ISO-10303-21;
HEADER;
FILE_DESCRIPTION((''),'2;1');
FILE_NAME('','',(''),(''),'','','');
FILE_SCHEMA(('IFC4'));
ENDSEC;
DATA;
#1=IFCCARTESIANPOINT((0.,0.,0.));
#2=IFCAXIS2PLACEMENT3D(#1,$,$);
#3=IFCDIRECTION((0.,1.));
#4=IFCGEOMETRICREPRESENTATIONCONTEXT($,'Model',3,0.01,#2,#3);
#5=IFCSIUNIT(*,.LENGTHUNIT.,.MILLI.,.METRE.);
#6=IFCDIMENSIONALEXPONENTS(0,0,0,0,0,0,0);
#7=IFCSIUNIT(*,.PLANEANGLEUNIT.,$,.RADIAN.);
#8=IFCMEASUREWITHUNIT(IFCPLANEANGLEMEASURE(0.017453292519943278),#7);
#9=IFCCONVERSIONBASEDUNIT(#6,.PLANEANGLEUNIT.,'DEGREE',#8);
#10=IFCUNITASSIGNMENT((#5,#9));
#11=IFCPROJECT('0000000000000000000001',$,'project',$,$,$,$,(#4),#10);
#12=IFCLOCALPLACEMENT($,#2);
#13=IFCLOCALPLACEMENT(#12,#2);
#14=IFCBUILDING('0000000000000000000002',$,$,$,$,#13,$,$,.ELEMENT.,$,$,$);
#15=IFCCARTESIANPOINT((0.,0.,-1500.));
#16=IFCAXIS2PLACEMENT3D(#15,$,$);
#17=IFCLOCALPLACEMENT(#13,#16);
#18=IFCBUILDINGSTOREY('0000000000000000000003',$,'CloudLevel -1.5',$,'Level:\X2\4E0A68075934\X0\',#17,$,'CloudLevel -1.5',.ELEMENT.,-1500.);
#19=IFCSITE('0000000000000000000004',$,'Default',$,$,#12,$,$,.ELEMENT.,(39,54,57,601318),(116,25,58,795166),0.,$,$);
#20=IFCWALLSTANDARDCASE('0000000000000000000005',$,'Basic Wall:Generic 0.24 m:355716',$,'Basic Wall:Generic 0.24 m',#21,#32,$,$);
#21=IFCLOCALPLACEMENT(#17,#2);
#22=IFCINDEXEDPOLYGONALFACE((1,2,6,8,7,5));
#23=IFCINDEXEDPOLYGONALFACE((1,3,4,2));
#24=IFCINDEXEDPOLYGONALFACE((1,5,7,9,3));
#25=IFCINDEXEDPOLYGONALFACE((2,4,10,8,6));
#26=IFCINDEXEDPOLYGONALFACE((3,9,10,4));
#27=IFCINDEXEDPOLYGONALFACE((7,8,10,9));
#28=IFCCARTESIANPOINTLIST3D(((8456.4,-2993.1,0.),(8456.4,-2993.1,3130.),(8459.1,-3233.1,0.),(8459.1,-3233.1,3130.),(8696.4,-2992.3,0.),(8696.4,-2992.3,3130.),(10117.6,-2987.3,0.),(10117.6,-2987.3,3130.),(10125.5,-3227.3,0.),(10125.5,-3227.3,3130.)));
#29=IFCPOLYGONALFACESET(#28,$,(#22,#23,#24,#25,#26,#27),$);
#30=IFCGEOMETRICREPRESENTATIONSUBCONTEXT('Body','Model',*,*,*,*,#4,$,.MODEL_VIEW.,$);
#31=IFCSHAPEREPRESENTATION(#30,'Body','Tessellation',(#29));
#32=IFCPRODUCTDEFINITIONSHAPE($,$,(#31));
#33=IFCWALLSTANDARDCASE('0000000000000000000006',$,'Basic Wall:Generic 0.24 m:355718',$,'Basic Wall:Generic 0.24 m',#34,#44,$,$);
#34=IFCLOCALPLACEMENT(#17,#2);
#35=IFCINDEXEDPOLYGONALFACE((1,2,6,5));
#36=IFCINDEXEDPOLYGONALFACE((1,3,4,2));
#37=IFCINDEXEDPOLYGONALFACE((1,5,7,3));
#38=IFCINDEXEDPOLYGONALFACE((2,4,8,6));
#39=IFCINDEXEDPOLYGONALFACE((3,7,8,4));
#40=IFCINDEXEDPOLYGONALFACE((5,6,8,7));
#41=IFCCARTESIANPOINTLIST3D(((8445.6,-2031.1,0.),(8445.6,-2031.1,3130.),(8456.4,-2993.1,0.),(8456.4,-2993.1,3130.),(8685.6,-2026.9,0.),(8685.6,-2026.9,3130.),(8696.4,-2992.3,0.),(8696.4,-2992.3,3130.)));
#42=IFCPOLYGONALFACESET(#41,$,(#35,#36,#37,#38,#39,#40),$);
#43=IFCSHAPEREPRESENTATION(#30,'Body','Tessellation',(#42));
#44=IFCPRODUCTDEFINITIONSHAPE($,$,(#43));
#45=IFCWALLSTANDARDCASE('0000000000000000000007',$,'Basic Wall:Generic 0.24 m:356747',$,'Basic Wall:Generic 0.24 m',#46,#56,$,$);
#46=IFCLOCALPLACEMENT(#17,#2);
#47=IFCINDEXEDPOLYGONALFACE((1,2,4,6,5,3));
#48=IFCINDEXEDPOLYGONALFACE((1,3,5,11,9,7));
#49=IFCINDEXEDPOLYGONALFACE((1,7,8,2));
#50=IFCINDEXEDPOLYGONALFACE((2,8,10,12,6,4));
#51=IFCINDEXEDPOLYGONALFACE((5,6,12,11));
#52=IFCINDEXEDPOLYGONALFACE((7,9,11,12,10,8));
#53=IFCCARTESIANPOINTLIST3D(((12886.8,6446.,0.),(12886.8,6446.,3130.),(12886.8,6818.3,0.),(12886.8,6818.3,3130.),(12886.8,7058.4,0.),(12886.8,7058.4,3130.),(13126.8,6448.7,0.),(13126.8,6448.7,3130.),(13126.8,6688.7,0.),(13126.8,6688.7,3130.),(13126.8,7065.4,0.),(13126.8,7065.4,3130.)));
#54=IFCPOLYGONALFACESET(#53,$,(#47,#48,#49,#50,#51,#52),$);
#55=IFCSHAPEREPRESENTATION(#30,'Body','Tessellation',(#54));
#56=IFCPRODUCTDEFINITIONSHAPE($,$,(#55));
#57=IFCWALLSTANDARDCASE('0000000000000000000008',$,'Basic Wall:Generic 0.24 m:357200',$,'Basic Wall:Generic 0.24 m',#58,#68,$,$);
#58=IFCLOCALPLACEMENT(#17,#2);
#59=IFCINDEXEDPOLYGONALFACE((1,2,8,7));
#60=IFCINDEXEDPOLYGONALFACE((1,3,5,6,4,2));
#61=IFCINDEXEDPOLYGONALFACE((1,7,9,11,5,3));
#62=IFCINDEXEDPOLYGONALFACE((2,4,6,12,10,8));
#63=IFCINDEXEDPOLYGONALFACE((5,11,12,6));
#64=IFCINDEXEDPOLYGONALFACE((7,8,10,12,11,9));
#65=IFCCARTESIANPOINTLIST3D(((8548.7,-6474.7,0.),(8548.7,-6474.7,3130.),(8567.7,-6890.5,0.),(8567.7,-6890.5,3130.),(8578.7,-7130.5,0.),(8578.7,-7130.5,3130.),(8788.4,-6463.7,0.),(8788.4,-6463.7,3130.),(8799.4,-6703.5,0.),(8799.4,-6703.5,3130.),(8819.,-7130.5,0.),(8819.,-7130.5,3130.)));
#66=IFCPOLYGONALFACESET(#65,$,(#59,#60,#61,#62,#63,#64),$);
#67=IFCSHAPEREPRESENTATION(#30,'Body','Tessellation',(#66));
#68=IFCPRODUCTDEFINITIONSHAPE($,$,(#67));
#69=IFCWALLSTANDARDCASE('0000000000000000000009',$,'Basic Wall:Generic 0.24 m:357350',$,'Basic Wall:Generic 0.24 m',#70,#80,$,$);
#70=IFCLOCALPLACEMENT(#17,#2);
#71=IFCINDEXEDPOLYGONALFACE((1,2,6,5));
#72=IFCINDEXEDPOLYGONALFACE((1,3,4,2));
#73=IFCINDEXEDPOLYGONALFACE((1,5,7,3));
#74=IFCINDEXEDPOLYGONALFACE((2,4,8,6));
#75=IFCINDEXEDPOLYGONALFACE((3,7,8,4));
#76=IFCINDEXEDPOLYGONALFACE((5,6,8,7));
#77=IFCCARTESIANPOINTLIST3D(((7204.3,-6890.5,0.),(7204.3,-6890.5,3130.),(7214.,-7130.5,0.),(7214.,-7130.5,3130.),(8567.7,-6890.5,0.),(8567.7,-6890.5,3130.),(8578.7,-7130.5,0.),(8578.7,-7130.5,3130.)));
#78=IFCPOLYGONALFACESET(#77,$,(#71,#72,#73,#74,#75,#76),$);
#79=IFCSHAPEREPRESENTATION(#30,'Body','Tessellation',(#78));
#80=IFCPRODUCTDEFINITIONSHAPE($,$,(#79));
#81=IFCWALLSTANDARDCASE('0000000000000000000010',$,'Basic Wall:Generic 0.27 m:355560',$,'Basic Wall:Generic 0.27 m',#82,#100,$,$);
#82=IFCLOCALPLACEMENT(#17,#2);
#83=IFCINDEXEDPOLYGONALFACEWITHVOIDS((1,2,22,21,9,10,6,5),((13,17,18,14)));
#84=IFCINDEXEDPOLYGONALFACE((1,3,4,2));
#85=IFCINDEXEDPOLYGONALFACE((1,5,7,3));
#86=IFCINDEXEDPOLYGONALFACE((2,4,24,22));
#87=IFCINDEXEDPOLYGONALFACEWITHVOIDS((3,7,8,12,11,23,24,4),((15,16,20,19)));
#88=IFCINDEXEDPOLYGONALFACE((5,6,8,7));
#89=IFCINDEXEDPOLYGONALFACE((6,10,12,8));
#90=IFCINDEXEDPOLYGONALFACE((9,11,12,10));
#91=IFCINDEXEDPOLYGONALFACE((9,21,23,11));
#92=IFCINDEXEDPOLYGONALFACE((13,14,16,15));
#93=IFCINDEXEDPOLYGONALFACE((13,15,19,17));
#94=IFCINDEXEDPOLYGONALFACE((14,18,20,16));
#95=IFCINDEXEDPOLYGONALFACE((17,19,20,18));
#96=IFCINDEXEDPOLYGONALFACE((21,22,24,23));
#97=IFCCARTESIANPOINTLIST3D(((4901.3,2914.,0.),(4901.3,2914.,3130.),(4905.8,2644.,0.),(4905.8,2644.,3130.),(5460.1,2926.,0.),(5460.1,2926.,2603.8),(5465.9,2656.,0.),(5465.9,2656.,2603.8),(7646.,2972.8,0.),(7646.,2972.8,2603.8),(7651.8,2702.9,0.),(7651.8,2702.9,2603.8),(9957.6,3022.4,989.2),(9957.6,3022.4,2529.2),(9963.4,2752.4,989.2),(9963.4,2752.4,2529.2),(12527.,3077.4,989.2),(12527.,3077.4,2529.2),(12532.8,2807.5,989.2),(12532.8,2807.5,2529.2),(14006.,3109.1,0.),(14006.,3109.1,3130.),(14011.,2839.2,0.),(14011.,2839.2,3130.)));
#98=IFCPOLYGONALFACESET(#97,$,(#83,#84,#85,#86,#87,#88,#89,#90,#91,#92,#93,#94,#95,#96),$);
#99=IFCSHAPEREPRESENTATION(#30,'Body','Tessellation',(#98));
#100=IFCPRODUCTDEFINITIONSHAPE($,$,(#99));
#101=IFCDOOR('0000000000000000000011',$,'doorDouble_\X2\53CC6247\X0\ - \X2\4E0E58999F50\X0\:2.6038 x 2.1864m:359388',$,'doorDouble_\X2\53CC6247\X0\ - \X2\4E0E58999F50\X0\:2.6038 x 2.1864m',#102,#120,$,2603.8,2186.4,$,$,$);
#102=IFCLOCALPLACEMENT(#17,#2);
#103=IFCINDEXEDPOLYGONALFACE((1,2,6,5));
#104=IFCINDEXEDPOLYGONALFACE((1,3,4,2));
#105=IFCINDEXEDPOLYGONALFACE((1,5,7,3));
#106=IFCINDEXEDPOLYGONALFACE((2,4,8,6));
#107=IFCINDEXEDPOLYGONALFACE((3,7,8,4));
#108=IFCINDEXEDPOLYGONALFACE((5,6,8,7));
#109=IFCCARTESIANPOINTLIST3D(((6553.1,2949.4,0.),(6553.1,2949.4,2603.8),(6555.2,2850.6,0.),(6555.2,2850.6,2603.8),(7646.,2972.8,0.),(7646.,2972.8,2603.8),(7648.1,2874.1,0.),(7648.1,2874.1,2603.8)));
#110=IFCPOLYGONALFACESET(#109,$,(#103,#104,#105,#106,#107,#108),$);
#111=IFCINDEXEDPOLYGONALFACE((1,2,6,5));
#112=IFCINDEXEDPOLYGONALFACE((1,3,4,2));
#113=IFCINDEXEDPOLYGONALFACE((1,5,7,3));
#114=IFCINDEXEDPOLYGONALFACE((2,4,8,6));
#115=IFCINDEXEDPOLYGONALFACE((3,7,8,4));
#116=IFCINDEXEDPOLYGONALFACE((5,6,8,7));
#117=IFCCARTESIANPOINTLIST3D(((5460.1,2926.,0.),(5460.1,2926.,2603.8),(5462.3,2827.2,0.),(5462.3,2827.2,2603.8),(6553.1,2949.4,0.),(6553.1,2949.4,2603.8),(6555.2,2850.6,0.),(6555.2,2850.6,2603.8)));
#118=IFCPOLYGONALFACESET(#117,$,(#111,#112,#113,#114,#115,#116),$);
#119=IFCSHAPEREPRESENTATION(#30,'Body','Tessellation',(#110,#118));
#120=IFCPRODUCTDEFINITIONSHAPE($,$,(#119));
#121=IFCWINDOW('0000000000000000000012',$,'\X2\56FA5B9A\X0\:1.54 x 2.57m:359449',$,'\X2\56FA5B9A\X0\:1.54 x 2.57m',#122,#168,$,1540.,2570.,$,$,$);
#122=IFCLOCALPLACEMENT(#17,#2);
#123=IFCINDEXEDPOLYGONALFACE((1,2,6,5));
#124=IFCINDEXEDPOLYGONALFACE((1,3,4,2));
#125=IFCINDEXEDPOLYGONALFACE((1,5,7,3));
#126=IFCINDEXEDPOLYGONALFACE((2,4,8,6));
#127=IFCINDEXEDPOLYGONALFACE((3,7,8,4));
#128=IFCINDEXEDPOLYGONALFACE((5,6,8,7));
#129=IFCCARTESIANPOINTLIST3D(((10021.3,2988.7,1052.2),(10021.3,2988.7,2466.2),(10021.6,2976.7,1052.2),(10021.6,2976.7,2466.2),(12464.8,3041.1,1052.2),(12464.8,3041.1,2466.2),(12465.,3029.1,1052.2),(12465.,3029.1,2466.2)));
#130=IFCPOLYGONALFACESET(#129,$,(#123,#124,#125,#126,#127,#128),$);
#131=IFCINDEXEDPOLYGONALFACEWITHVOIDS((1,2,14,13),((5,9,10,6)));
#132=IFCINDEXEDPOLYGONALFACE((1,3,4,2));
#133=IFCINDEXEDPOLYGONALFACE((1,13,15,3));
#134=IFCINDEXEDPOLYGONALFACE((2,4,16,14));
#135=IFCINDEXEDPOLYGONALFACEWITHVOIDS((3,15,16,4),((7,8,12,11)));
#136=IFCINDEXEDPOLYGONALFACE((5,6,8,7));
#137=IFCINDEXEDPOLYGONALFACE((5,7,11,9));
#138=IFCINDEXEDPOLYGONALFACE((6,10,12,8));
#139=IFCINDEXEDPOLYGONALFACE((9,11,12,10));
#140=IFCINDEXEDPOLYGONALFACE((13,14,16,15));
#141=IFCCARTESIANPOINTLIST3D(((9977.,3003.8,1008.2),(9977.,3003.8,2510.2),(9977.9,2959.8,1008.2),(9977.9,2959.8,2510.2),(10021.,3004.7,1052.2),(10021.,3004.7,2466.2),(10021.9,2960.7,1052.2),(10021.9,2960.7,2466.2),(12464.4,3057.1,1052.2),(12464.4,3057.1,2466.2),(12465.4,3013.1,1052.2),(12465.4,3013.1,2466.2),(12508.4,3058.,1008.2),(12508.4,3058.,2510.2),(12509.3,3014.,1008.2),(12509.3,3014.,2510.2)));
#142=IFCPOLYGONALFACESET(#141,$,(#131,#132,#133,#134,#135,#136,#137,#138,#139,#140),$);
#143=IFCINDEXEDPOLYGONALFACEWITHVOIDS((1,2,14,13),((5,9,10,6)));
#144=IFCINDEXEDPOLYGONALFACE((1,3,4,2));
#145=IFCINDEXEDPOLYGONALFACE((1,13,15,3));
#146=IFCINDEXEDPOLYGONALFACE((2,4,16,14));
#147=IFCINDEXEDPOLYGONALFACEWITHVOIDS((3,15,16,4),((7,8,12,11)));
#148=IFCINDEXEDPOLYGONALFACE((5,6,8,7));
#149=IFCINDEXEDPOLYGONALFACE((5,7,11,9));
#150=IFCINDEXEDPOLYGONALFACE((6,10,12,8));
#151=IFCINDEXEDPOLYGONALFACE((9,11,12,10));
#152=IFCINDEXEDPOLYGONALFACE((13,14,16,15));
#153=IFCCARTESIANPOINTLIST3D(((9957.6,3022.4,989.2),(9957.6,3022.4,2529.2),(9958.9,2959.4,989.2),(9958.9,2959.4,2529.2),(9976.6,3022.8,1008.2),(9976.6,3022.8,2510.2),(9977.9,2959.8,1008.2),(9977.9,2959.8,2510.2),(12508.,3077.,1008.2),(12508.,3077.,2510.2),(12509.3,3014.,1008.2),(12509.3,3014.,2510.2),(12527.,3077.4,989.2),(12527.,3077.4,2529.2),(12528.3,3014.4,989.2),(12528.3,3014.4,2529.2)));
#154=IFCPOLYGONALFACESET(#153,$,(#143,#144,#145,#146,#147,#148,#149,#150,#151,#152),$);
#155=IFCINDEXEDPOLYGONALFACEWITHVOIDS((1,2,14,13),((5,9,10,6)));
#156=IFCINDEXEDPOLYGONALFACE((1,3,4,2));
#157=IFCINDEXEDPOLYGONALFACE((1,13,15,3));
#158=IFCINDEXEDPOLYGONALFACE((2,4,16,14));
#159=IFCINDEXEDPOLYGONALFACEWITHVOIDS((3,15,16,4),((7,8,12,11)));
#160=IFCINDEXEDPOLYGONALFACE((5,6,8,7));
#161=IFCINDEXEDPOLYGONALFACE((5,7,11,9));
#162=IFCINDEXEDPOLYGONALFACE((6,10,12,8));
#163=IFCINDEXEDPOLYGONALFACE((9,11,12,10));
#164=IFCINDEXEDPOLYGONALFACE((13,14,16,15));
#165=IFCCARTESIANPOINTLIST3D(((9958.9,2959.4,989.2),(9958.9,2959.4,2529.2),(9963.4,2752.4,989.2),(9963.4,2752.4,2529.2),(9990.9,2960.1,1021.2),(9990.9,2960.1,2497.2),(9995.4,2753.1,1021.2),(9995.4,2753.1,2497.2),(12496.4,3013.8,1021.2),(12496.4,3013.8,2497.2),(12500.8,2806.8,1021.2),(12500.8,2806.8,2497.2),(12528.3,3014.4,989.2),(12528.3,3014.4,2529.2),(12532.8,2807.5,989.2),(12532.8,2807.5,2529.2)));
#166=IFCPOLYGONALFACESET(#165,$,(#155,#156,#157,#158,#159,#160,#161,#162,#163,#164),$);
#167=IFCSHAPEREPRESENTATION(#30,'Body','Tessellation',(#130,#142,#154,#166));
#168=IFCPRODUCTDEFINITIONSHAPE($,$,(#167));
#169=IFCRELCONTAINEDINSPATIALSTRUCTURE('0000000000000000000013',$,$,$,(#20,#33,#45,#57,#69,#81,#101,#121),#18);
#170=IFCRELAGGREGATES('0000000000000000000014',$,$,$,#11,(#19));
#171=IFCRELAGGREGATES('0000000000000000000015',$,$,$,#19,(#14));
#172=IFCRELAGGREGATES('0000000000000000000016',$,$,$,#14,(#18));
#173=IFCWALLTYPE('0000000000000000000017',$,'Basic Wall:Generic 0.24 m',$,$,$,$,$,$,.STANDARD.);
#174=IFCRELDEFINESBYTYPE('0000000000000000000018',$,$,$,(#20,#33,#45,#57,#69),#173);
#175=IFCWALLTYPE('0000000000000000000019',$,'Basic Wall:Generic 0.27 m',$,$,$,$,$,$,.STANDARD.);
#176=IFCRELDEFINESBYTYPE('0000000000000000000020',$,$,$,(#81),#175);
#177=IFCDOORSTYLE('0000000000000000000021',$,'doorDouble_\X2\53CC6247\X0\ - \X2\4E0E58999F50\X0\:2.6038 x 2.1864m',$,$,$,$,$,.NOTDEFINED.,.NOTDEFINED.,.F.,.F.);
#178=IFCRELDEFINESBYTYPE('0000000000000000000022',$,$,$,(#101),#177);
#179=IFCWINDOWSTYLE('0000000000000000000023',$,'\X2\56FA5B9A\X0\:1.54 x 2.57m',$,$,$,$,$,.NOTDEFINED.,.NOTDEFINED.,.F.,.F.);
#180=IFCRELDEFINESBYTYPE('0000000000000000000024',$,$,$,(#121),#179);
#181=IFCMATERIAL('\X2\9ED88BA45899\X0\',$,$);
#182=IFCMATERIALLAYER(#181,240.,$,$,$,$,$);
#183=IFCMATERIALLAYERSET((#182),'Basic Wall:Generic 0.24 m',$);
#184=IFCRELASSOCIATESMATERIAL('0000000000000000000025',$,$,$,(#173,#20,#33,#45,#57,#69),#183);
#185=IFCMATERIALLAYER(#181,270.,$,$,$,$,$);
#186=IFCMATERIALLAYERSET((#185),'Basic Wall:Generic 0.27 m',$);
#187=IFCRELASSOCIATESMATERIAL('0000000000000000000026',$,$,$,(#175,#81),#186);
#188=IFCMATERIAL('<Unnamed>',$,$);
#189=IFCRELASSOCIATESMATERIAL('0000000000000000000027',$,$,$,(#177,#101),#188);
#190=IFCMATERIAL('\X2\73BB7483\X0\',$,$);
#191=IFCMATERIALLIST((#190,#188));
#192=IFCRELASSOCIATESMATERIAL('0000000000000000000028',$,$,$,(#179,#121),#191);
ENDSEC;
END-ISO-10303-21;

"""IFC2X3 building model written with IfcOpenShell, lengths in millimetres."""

from ifc_helpers import new_model, entity, si_unit, converted_unit, direction, frame, frame_2d, origin, place, context, subcontext, project, spatial, polyline, rectangle, outline, extrude, source, transform, mapped, material, material_list, layer, layer_set, layer_usage, type_object, type_shapes, element, fill, save


model = new_model("IFC2X3")

# Units and contexts
model_context = context("Model", 3, precision=0.01, world=origin(), true_north=direction((0.0, 1.0)))
body_context = subcontext(model_context, "Body", "Model", "MODEL_VIEW")
ifc_project = project(units=[si_unit("LENGTHUNIT", "METRE", prefix="MILLI"), converted_unit("PLANEANGLEUNIT", "DEGREE", entity("IfcPlaneAngleMeasure", 0.017453292519943278), si_unit("PLANEANGLEUNIT", "RADIAN"), dimensions=[0, 0, 0, 0, 0, 0, 0])], contexts=[model_context])

# Site, building, storey
site_placement = place(None, origin())
site = spatial("IfcSite", under=ifc_project, at=site_placement, Name="Default", CompositionType="ELEMENT", RefLatitude=(39, 54, 57, 601318), RefLongitude=(116, 25, 58, 795166), RefElevation=0.0)
building_placement = place(site_placement, origin())
building = spatial("IfcBuilding", under=site, at=building_placement, CompositionType="ELEMENT")
storey_placement = place(building_placement, frame((0.0, 0.0, -1500.0)))
storey = spatial("IfcBuildingStorey", under=building, at=storey_placement, Name="CloudLevel -1.5", ObjectType="Level:上标头", LongName="CloudLevel -1.5", CompositionType="ELEMENT", Elevation=-1500.0)

# Shared definitions
ifc_material_1 = material(Name="默认墙")
ifc_layer_1 = layer(ifc_material_1, 240.0)
ifc_layer_set_1 = layer_set([ifc_layer_1], Name="Basic Wall:Generic 0.24 m")
ifc_layer_usage_1 = layer_usage(ifc_layer_set_1, "AXIS2", "NEGATIVE", 120.0)
wall_type_1 = type_object("IfcWallType", Name="Basic Wall:Generic 0.24 m", PredefinedType="STANDARD", material=ifc_layer_set_1)

# Shared definitions
ifc_material_2 = material(Name="玻璃")
ifc_material_3 = material(Name="<Unnamed>")
ifc_material_list_1 = material_list([ifc_material_2, ifc_material_3])

# Walls
wall_1_placement = place(storey_placement, frame((10125.0, -3107.3, 0.0), z_axis=(0.0, 0.0, 1.0), x_axis=(-0.999994, -0.003487, 0.0)))
element("IfcWallStandardCase", 1, at=wall_1_placement, inside=storey, type_object=wall_type_1, material=ifc_layer_usage_1, Name="Basic Wall:Generic 0.24 m:355716", ObjectType="Basic Wall:Generic 0.24 m", context=body_context, shape_type="SweptSolid", body=[
    extrude(outline(polyline([(1668.2, -120.0), (1666.4, 120.0), (0.0, 120.0), (7.0, -120.0), (1428.2, -120.0), (1668.2, -120.0)])), origin(), (0.0, 0.0, 1.0), 3130.0),
])
wall_2_placement = place(storey_placement, frame((8576.4, -2993.6, 0.0), z_axis=(0.0, 0.0, 1.0), x_axis=(-0.011185, 0.999937, 0.0)))
element("IfcWallStandardCase", 2, at=wall_2_placement, inside=storey, type_object=wall_type_1, material=ifc_layer_usage_1, Name="Basic Wall:Generic 0.24 m:355718", ObjectType="Basic Wall:Generic 0.24 m", context=body_context, shape_type="SweptSolid", body=[
    extrude(outline(polyline([(965.4, -120.0), (963.9, 120.0), (1.8, 120.0), (0.0, -120.0), (965.4, -120.0)])), origin(), (0.0, 0.0, 1.0), 3130.0),
])
wall_3_placement = place(storey_placement, frame((13006.8, 6446.0, 0.0), z_axis=(0.0, 0.0, 1.0), x_axis=(0.0, 1.0, 0.0)))
element("IfcWallStandardCase", 3, at=wall_3_placement, inside=storey, type_object=wall_type_1, material=ifc_layer_usage_1, Name="Basic Wall:Generic 0.24 m:356747", ObjectType="Basic Wall:Generic 0.24 m", context=body_context, shape_type="SweptSolid", body=[
    extrude(outline(polyline([(619.3, -120.0), (612.3, 120.0), (372.2, 120.0), (0.0, 120.0), (2.7, -120.0), (242.7, -120.0), (619.3, -120.0)])), origin(), (0.0, 0.0, 1.0), 3130.0),
])
wall_4_placement = place(storey_placement, frame((8668.6, -6469.2, 0.0), z_axis=(0.0, 0.0, 1.0), x_axis=(0.045709, -0.998955, 0.0)))
element("IfcWallStandardCase", 4, at=wall_4_placement, inside=storey, type_object=wall_type_1, material=ifc_layer_usage_1, Name="Basic Wall:Generic 0.24 m:357200", ObjectType="Basic Wall:Generic 0.24 m", context=body_context, shape_type="SweptSolid", body=[
    extrude(outline(polyline([(656.5, -120.0), (667.4, 120.0), (240.0, 120.0), (0.0, 120.0), (0.0, -120.0), (416.2, -120.0), (656.5, -120.0)])), origin(), (0.0, 0.0, 1.0), 3130.0),
])
wall_5_placement = place(storey_placement, frame((8578.7, -7010.5, 0.0), z_axis=(0.0, 0.0, 1.0), x_axis=(-1.0, 0.0, 0.0)))
element("IfcWallStandardCase", 5, at=wall_5_placement, inside=storey, type_object=wall_type_1, material=ifc_layer_usage_1, Name="Basic Wall:Generic 0.24 m:357350", ObjectType="Basic Wall:Generic 0.24 m", context=body_context, shape_type="SweptSolid", body=[
    extrude(outline(polyline([(1374.4, -120.0), (1364.7, 120.0), (0.0, 120.0), (11.0, -120.0), (1374.4, -120.0)])), origin(), (0.0, 0.0, 1.0), 3130.0),
])

# Wall, openings, door, window
ifc_layer_2 = layer(ifc_material_1, 270.0)
ifc_layer_set_2 = layer_set([ifc_layer_2], Name="Basic Wall:Generic 0.27 m")
ifc_layer_usage_2 = layer_usage(ifc_layer_set_2, "AXIS2", "NEGATIVE", 135.0)
wall_type_2 = type_object("IfcWallType", Name="Basic Wall:Generic 0.27 m", PredefinedType="STANDARD", material=ifc_layer_set_2)
wall_6_placement = place(storey_placement, frame((14008.9, 2974.2, 0.0), z_axis=(0.0, 0.0, 1.0), x_axis=(-0.99977, -0.021426, 0.0)))
wall_6 = element("IfcWallStandardCase", 6, at=wall_6_placement, inside=storey, type_object=wall_type_2, material=ifc_layer_usage_2, Name="Basic Wall:Generic 0.27 m:355560", ObjectType="Basic Wall:Generic 0.27 m", context=body_context, shape_type="SweptSolid", body=[
    extrude(outline(polyline([(0.0, -135.0), (240.0, -135.0), (2980.9, -135.0), (3180.9, -135.0), (5994.7, -135.0), (6324.8, -135.0), (9106.8, -135.0), (9108.1, 135.0), (4370.7, 135.0), (4060.7, 135.0), (0.8, 135.0), (0.0, -135.0)])), origin(), (0.0, 0.0, 1.0), 3130.0),
])
opening_1_placement = place(wall_6_placement, frame((6361.5, -135.0, 0.0)))
opening_1 = element("IfcOpeningElement", 7, at=opening_1_placement, cuts=wall_6, ObjectType="Opening", context=body_context, shape_type="SweptSolid", body=[
    extrude(rectangle(XDim=2603.8, YDim=2186.4, at=frame_2d((1301.9, 1093.2), x_axis=(1.0, 0.0))), frame((0.0, 0.0, 0.0), z_axis=(0.0, 1.0, 0.0), x_axis=(0.0, 0.0, 1.0)), (0.0, 0.0, 1.0), 270.0),
])
opening_2_placement = place(wall_6_placement, frame((4049.3, 135.0, 989.2)))
opening_2 = element("IfcOpeningElement", 8, at=opening_2_placement, cuts=wall_6, ObjectType="Opening", context=body_context, shape_type="SweptSolid", body=[
    extrude(rectangle(XDim=1540.0, YDim=2570.0, at=frame_2d((770.0, 1285.0), x_axis=(1.0, 0.0))), frame((0.0, 0.0, 0.0), z_axis=(0.0, -1.0, 0.0), x_axis=(0.0, 0.0, 1.0)), (0.0, 0.0, 1.0), 270.0),
])
door_style_1 = type_object("IfcDoorStyle", Name="doorDouble_双扇 - 与墙齐:2.6038 x 2.1864m", ConstructionType="NOTDEFINED", OperationType="NOTDEFINED", ParameterTakesPrecedence=False, Sizeable=False, material=ifc_material_3)
shared_shape_1 = source(origin(), body_context, "Body", "SweptSolid", [
    extrude(rectangle(XDim=1093.2, YDim=98.8, at=frame_2d((0.0, 0.0), x_axis=(1.0, 0.0))), frame((1639.8, 220.6, 0.0), z_axis=(0.0, 0.0, 1.0), x_axis=(-1.0, 0.0, 0.0)), (0.0, 0.0, 1.0), 2603.8),
    extrude(rectangle(XDim=1093.2, YDim=98.8, at=frame_2d((0.0, 0.0), x_axis=(1.0, 0.0))), frame((546.6, 220.6, 0.0), z_axis=(0.0, 0.0, 1.0), x_axis=(-1.0, 0.0, 0.0)), (0.0, 0.0, 1.0), 2603.8),
])
type_shapes(door_style_1, [shared_shape_1])
door_1_placement = place(opening_1_placement, frame((2186.4, 270.0, 0.0), z_axis=(0.0, 0.0, 1.0), x_axis=(-1.0, 0.0, 0.0)))
door_1 = element("IfcDoor", 9, at=door_1_placement, inside=storey, type_object=door_style_1, material=ifc_material_3, Name="doorDouble_双扇 - 与墙齐:2.6038 x 2.1864m:359388", ObjectType="doorDouble_双扇 - 与墙齐:2.6038 x 2.1864m", OverallHeight=2603.8, OverallWidth=2186.4, context=body_context, shape_type="MappedRepresentation", body=[
    mapped(shared_shape_1, transform((0.0, 0.0, 0.0), scale=1.0)),
])
fill(opening_1, door_1)
window_style_1 = type_object("IfcWindowStyle", Name="固定:1.54 x 2.57m", ConstructionType="NOTDEFINED", OperationType="NOTDEFINED", ParameterTakesPrecedence=False, Sizeable=False, material=ifc_material_list_1)
shared_shape_2 = source(origin(), body_context, "Body", "SweptSolid", [
    extrude(rectangle(XDim=2444.0, YDim=12.0, at=frame_2d((0.0, 0.0), x_axis=(1.0, 0.0))), frame((1285.0, 255.0, 63.0), z_axis=(0.0, 0.0, 1.0), x_axis=(-1.0, 0.0, 0.0)), (0.0, 0.0, 1.0), 1414.0),
    extrude(outline(polyline([(-1266.0, -751.0), (1266.0, -751.0), (1266.0, 751.0), (-1266.0, 751.0), (-1266.0, -751.0)]), holes=[polyline([(-1222.0, -707.0), (-1222.0, 707.0), (1222.0, 707.0), (1222.0, -707.0), (-1222.0, -707.0)])]), frame((1285.0, 277.0, 770.0), z_axis=(0.0, -1.0, 0.0), x_axis=(-1.0, 0.0, 0.0)), (0.0, 0.0, 1.0), 44.0),
    extrude(outline(polyline([(-1285.0, -770.0), (1285.0, -770.0), (1285.0, 770.0), (-1285.0, 770.0), (-1285.0, -770.0)]), holes=[polyline([(-1266.0, -751.0), (-1266.0, 751.0), (1266.0, 751.0), (1266.0, -751.0), (-1266.0, -751.0)])]), frame((1285.0, 296.0, 770.0), z_axis=(0.0, -1.0, 0.0), x_axis=(-1.0, 0.0, 0.0)), (0.0, 0.0, 1.0), 63.0),
    extrude(outline(polyline([(-1285.0, -770.0), (1285.0, -770.0), (1285.0, 770.0), (-1285.0, 770.0), (-1285.0, -770.0)]), holes=[polyline([(-1253.0, -738.0), (-1253.0, 738.0), (1253.0, 738.0), (1253.0, -738.0), (-1253.0, -738.0)])]), frame((1285.0, 233.0, 770.0), z_axis=(0.0, -1.0, 0.0), x_axis=(-1.0, 0.0, 0.0)), (0.0, 0.0, 1.0), 207.0),
])
type_shapes(window_style_1, [shared_shape_2])
window_1_placement = place(opening_2_placement, frame((0.0, 26.0, 0.0), z_axis=(0.0, 0.0, 1.0), x_axis=(-1.0, 0.0, 0.0)))
window_1 = element("IfcWindow", 10, at=window_1_placement, inside=storey, type_object=window_style_1, material=ifc_material_list_1, Name="固定:1.54 x 2.57m:359449", ObjectType="固定:1.54 x 2.57m", OverallHeight=1540.0, OverallWidth=2570.0, context=body_context, shape_type="MappedRepresentation", body=[
    mapped(shared_shape_2, transform((0.0, 0.0, 0.0), scale=1.0)),
])
fill(opening_2, window_1)

save(model, "model.ifc")
